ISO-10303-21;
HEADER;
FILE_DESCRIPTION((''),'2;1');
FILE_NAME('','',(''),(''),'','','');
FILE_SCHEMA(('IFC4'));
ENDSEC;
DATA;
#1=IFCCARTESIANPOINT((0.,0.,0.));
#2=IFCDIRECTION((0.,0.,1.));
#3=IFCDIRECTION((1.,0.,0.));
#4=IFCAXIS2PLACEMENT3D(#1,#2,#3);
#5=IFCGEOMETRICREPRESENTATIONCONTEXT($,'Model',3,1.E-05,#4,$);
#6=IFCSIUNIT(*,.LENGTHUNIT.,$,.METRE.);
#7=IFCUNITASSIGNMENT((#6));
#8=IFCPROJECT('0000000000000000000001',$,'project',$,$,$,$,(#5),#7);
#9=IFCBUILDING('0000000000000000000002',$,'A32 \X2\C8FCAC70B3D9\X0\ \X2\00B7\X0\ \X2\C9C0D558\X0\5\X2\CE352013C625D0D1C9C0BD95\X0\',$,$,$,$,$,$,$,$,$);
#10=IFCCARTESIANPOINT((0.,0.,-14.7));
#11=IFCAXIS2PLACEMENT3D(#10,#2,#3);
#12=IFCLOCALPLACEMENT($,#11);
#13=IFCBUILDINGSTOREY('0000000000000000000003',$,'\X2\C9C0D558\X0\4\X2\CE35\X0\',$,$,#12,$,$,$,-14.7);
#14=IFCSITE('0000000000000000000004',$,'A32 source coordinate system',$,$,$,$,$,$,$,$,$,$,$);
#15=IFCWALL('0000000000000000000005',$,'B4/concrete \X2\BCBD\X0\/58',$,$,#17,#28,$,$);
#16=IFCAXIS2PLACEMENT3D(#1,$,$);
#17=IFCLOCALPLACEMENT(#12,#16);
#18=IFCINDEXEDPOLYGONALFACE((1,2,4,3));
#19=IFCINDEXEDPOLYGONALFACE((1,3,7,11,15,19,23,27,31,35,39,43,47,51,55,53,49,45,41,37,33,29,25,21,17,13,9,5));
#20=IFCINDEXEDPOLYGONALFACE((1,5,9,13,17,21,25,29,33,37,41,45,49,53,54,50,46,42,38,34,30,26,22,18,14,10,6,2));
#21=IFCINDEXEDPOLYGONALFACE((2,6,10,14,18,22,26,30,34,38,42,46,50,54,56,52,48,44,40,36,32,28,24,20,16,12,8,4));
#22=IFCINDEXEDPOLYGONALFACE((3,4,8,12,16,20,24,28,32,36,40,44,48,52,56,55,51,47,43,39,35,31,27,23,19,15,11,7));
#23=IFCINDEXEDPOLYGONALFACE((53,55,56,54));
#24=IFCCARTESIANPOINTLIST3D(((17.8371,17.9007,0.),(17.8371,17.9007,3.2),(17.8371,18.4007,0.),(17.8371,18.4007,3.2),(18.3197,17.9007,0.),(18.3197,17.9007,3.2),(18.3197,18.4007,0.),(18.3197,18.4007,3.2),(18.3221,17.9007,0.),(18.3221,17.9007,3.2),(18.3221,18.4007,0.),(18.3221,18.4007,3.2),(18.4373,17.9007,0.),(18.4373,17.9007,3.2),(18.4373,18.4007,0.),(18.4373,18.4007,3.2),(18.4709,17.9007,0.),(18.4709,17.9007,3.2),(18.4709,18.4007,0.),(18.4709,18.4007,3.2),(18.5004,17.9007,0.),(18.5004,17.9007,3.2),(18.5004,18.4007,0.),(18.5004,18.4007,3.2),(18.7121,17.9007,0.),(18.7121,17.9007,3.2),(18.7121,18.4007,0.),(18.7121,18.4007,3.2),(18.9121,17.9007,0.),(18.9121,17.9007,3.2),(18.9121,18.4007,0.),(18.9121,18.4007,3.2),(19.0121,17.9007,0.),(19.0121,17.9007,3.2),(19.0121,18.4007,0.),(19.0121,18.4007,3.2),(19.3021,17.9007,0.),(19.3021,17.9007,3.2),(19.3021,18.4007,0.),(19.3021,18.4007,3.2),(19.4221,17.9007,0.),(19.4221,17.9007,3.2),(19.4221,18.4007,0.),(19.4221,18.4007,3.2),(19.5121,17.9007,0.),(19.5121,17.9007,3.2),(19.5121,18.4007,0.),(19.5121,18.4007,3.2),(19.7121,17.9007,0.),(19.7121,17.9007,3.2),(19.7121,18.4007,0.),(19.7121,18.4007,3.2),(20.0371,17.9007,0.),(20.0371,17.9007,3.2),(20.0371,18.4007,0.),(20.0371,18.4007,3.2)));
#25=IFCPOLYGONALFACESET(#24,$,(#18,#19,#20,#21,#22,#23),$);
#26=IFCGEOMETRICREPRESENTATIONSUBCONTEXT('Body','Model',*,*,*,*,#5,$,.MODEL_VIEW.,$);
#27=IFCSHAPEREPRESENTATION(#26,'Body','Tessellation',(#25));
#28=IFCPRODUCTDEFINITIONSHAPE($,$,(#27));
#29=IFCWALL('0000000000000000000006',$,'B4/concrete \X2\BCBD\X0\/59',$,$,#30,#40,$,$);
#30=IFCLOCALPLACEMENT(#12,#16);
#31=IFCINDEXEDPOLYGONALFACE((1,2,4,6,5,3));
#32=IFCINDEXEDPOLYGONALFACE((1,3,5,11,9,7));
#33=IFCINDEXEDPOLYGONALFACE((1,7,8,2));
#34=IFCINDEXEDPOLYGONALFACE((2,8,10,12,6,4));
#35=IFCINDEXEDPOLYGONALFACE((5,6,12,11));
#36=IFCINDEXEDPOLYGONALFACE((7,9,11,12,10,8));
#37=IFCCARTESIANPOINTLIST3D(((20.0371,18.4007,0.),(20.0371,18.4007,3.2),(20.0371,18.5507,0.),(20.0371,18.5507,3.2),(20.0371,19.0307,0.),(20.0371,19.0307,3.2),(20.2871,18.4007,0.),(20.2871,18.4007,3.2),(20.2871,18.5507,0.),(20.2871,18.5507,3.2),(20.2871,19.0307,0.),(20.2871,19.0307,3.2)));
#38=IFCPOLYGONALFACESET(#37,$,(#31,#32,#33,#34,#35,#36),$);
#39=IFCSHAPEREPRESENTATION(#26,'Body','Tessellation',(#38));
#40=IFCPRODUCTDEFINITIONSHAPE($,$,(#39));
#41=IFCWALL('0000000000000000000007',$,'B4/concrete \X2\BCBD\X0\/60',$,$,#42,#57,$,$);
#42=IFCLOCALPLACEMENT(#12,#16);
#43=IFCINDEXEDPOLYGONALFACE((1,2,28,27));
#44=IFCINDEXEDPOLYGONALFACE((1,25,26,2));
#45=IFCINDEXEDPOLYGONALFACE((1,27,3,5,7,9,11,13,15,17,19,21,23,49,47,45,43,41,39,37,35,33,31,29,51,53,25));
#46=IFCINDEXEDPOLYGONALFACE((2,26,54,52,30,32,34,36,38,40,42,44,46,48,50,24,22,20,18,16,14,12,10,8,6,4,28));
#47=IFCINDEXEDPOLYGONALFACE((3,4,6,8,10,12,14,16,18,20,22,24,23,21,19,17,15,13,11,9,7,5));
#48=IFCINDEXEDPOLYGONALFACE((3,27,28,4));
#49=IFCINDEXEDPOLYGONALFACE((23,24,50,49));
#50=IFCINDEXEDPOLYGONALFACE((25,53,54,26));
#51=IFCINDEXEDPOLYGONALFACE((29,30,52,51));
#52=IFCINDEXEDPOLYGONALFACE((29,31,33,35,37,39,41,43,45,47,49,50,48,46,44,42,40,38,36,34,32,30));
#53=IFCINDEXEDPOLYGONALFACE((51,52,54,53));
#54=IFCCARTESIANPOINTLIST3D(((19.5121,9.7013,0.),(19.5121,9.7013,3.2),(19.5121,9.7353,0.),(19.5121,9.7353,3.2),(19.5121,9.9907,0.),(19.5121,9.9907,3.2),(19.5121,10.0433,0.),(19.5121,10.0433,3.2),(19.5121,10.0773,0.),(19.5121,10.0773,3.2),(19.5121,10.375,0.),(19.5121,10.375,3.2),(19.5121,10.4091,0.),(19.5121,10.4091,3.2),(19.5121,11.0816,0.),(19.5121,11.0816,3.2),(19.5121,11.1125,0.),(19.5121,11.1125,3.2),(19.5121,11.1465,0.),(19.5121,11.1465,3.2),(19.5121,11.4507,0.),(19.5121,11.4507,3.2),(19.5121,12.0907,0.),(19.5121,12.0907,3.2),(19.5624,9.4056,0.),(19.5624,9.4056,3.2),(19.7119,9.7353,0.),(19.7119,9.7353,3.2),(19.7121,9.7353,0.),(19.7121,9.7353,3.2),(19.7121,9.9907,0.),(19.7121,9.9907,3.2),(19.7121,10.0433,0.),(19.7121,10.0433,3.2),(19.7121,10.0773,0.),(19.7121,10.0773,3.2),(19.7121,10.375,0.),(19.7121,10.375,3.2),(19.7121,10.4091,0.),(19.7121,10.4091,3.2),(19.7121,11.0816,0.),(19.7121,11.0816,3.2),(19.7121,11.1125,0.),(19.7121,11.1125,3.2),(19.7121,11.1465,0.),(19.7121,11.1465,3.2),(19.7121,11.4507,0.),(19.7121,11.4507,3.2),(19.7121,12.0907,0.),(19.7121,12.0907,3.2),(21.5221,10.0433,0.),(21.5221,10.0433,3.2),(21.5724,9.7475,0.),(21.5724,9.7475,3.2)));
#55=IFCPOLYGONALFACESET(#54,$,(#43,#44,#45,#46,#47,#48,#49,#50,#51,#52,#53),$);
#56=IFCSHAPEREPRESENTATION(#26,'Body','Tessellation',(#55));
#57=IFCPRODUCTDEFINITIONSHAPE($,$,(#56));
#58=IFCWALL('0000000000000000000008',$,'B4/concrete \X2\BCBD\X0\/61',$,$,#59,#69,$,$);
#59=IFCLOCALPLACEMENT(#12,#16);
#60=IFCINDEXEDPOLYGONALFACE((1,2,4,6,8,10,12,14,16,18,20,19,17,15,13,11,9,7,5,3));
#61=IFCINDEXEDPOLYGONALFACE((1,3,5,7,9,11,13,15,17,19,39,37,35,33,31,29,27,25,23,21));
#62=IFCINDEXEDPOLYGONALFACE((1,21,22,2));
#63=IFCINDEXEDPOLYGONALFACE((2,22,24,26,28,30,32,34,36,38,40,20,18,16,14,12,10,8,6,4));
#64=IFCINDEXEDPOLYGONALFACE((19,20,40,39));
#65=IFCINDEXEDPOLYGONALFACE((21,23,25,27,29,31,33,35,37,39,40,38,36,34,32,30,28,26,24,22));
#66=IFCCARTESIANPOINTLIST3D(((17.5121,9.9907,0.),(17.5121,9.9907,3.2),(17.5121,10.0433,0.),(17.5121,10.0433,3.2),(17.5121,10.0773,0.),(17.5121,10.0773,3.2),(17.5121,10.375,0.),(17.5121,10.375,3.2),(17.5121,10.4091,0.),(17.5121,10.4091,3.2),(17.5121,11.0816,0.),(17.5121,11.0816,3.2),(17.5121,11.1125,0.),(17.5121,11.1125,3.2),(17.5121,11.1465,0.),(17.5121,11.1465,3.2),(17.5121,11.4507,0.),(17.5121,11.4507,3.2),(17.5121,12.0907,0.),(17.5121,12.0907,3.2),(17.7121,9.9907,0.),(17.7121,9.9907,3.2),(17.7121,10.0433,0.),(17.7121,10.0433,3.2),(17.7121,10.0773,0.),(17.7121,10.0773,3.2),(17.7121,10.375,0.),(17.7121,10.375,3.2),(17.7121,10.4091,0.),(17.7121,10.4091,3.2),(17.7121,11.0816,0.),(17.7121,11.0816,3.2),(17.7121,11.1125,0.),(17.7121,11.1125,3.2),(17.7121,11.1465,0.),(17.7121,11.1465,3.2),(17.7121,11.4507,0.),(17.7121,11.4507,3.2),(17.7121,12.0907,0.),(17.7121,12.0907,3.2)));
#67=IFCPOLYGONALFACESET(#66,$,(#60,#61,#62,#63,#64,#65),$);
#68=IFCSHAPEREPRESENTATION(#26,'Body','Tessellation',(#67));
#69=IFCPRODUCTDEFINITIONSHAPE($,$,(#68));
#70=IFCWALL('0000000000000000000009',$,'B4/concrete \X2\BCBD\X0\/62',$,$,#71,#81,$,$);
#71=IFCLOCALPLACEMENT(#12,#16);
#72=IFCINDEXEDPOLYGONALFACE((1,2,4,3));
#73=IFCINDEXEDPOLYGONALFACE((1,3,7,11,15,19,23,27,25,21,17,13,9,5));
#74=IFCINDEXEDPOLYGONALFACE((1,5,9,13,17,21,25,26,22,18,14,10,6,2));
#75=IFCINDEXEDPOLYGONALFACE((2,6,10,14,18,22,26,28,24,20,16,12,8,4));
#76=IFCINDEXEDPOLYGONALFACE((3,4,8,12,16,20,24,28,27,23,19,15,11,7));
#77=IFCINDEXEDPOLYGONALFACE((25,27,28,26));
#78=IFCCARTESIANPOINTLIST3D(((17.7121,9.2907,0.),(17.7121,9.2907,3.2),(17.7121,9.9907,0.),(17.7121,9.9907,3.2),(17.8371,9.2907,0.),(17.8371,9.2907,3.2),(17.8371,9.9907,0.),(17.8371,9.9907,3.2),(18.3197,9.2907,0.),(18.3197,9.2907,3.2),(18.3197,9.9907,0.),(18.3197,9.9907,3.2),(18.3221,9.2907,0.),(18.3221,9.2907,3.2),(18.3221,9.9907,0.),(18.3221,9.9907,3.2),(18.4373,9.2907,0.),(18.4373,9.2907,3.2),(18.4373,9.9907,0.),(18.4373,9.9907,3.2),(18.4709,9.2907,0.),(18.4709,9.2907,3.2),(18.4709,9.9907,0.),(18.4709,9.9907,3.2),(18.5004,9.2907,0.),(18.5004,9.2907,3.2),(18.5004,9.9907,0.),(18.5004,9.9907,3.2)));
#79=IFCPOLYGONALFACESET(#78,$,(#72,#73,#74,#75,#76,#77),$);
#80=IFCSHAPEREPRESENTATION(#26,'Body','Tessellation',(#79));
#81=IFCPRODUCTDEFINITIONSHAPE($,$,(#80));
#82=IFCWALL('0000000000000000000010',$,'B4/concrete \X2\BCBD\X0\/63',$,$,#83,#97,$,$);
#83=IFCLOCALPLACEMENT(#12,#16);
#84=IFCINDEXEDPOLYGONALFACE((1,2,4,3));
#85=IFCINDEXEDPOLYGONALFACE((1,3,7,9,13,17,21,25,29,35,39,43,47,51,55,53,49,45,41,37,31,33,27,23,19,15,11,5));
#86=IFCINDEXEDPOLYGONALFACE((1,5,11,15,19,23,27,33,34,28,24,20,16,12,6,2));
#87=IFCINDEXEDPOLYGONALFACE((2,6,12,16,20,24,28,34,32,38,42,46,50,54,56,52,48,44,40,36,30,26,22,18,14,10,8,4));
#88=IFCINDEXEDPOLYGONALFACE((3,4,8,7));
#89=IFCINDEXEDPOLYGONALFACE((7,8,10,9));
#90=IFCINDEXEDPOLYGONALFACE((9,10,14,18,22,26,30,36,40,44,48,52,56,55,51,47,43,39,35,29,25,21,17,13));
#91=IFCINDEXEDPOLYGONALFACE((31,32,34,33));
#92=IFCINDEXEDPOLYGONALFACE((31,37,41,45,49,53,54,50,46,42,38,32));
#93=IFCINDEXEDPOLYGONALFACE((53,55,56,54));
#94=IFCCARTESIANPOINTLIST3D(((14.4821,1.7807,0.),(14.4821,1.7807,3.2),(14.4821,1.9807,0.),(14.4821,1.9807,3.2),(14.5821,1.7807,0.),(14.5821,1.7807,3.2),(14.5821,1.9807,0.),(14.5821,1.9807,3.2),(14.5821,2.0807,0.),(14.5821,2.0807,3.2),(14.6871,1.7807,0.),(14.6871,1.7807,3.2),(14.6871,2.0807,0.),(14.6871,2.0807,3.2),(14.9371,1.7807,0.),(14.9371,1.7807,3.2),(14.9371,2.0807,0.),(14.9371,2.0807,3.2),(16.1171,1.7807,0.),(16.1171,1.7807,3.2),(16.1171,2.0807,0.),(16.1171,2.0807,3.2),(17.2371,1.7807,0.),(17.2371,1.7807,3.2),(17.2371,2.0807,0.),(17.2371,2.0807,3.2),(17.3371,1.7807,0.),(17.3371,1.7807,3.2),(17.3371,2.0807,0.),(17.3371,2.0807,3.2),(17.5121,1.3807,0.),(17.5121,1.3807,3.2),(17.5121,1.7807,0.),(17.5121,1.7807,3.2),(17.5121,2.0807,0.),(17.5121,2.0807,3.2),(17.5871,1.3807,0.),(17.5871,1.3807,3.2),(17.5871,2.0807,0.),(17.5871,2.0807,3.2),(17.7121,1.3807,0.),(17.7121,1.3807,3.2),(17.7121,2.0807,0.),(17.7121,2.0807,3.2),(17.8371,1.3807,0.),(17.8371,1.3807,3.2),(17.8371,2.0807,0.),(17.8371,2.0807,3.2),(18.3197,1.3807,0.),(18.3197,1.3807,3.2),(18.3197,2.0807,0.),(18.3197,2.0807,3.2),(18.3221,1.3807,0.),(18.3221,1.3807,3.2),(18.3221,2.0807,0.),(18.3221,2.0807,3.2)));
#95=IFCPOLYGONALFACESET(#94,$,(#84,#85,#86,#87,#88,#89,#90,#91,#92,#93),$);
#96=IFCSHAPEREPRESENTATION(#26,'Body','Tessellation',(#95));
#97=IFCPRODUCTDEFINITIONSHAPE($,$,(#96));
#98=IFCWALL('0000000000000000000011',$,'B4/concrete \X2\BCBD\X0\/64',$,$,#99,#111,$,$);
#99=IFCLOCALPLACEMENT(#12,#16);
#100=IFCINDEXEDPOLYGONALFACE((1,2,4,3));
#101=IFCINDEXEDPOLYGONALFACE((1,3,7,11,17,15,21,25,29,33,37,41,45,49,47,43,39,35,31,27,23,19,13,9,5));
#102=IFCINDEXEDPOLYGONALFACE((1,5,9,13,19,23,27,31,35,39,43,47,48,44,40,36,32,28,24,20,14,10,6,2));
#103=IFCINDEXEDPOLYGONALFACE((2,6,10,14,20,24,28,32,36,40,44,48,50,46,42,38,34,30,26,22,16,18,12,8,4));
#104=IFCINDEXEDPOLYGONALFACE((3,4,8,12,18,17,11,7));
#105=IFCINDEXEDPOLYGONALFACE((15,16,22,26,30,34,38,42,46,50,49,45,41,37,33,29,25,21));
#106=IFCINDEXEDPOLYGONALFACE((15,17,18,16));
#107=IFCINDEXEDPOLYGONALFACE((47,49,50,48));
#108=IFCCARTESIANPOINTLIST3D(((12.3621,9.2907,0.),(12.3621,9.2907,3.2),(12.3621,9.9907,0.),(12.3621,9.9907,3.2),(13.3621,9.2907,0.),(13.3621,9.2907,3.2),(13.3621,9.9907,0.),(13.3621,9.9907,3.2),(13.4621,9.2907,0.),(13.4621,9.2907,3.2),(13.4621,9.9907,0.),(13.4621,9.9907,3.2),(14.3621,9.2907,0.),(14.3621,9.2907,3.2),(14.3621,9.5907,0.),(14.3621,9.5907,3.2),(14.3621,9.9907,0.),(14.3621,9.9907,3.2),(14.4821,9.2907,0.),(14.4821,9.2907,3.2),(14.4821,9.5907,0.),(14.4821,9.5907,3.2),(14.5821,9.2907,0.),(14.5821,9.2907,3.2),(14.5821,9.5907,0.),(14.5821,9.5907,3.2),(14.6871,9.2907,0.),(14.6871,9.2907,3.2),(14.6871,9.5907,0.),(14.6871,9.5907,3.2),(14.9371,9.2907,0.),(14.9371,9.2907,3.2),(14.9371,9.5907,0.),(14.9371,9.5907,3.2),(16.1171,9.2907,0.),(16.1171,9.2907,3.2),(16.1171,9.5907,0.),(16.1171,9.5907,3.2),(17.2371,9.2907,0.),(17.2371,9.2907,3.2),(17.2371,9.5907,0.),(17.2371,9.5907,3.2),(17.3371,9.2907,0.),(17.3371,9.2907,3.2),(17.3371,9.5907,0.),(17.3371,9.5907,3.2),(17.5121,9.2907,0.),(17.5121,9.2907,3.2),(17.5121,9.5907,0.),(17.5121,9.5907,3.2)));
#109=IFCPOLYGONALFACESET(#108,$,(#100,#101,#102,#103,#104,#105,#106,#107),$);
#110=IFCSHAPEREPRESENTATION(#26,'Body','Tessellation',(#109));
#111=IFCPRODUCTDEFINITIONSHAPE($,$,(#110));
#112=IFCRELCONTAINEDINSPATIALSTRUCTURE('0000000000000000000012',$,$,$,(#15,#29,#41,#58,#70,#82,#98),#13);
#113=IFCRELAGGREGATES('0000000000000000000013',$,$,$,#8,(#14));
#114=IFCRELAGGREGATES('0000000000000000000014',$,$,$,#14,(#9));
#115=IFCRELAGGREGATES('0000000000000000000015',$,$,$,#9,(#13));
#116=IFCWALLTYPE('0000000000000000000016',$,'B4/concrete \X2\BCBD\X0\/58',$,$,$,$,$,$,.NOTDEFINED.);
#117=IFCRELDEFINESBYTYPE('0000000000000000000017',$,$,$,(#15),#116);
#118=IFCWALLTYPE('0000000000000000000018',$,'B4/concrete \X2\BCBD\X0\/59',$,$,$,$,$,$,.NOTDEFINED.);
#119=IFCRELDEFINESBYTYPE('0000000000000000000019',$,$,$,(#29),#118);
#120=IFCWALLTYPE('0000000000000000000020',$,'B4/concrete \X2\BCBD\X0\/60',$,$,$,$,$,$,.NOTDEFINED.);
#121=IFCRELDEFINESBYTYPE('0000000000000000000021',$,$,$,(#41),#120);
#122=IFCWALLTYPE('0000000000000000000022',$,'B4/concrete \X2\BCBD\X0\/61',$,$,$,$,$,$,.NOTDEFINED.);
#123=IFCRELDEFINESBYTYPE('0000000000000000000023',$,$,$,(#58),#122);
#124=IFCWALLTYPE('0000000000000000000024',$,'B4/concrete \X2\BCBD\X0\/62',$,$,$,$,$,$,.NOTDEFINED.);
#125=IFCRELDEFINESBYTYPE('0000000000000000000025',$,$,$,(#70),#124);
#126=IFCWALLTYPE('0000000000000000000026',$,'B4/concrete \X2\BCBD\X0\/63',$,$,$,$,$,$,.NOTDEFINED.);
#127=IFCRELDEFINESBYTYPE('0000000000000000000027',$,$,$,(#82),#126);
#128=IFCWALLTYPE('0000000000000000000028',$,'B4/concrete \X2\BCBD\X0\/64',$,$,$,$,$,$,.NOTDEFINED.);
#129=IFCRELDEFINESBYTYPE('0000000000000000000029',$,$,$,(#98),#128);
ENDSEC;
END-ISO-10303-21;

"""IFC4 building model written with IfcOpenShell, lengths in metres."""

from ifc_helpers import new_model, si_unit, frame, origin, origin_with_axes, place, context, subcontext, project, spatial, polyline, outline, extrude, source, transform, mapped, type_object, type_shapes, element, save


model = new_model("IFC4")

# Units and contexts
model_context = context("Model", 3, precision=1e-05, world=origin_with_axes())
body_context = subcontext(model_context, "Body", "Model", "MODEL_VIEW")
ifc_project = project(units=[si_unit("LENGTHUNIT", "METRE")], contexts=[model_context])

# Site, building, storey
site = spatial("IfcSite", under=ifc_project, Name="A32 source coordinate system")
building = spatial("IfcBuilding", under=site, Name="A32 주거동 · 지하5층–옥탑지붕")
storey_placement = place(None, frame((0.0, 0.0, -14.7), z_axis=(0.0, 0.0, 1.0), x_axis=(1.0, 0.0, 0.0)))
storey = spatial("IfcBuildingStorey", under=building, at=storey_placement, Name="지하4층", Elevation=-14.7)

# Walls
wall_type_1 = type_object("IfcWallType", Name="B4/concrete 벽/58", PredefinedType="NOTDEFINED")
shared_shape_1 = source(origin(), body_context, "Body", "SweptSolid", [
    extrude(outline(polyline([(18.3221, 18.4007), (18.4373, 18.4007), (18.4709, 18.4007), (18.5004, 18.4007), (18.7121, 18.4007), (18.9121, 18.4007), (19.0121, 18.4007), (19.3021, 18.4007), (19.4221, 18.4007), (19.5121, 18.4007), (19.7121, 18.4007), (20.0371, 18.4007), (20.0371, 17.9007), (19.7121, 17.9007), (19.5121, 17.9007), (19.4221, 17.9007), (19.3021, 17.9007), (19.0121, 17.9007), (18.9121, 17.9007), (18.7121, 17.9007), (18.5004, 17.9007), (18.4709, 17.9007), (18.4373, 17.9007), (18.3221, 17.9007), (18.3197, 17.9007), (17.8371, 17.9007), (17.8371, 18.4007), (18.3197, 18.4007), (18.3221, 18.4007)])), origin(), (0.0, 0.0, 1.0), 3.2),
])
type_shapes(wall_type_1, [shared_shape_1])
wall_1_placement = place(storey_placement, origin_with_axes())
element("IfcWall", 1, at=wall_1_placement, inside=storey, type_object=wall_type_1, Name="B4/concrete 벽/58", context=body_context, shape_type="MappedRepresentation", body=[
    mapped(shared_shape_1, transform((0.0, 0.0, 0.0), scale=1.0)),
])
wall_type_2 = type_object("IfcWallType", Name="B4/concrete 벽/59", PredefinedType="NOTDEFINED")
shared_shape_2 = source(origin(), body_context, "Body", "SweptSolid", [
    extrude(outline(polyline([(20.2871, 19.0307), (20.2871, 18.5507), (20.2871, 18.4007), (20.0371, 18.4007), (20.0371, 18.5507), (20.0371, 19.0307), (20.2871, 19.0307)])), origin(), (0.0, 0.0, 1.0), 3.2),
])
type_shapes(wall_type_2, [shared_shape_2])
wall_2_placement = place(storey_placement, origin_with_axes())
element("IfcWall", 2, at=wall_2_placement, inside=storey, type_object=wall_type_2, Name="B4/concrete 벽/59", context=body_context, shape_type="MappedRepresentation", body=[
    mapped(shared_shape_2, transform((0.0, 0.0, 0.0), scale=1.0)),
])
wall_type_3 = type_object("IfcWallType", Name="B4/concrete 벽/60", PredefinedType="NOTDEFINED")
shared_shape_3 = source(origin(), body_context, "Body", "SweptSolid", [
    extrude(outline(polyline([(19.5121, 11.1465), (19.5121, 11.4507), (19.5121, 12.0907), (19.7121, 12.0907), (19.7121, 11.4507), (19.7121, 11.1465), (19.7121, 11.1125), (19.7121, 11.0816), (19.7121, 10.4091), (19.7121, 10.375), (19.7121, 10.0773), (19.7121, 10.0433), (19.7121, 9.9907), (19.7121, 9.7353), (21.5221, 10.0433), (21.5724, 9.7475), (19.5624, 9.4056), (19.5121, 9.7013), (19.7119, 9.7353), (19.5121, 9.7353), (19.5121, 9.9907), (19.5121, 10.0433), (19.5121, 10.0773), (19.5121, 10.375), (19.5121, 10.4091), (19.5121, 11.0816), (19.5121, 11.1125), (19.5121, 11.1465)])), origin(), (0.0, 0.0, 1.0), 3.2),
])
type_shapes(wall_type_3, [shared_shape_3])
wall_3_placement = place(storey_placement, origin_with_axes())
element("IfcWall", 3, at=wall_3_placement, inside=storey, type_object=wall_type_3, Name="B4/concrete 벽/60", context=body_context, shape_type="MappedRepresentation", body=[
    mapped(shared_shape_3, transform((0.0, 0.0, 0.0), scale=1.0)),
])
wall_type_4 = type_object("IfcWallType", Name="B4/concrete 벽/61", PredefinedType="NOTDEFINED")
shared_shape_4 = source(origin(), body_context, "Body", "SweptSolid", [
    extrude(outline(polyline([(17.5121, 11.4507), (17.5121, 12.0907), (17.7121, 12.0907), (17.7121, 11.4507), (17.7121, 11.1465), (17.7121, 11.1125), (17.7121, 11.0816), (17.7121, 10.4091), (17.7121, 10.375), (17.7121, 10.0773), (17.7121, 10.0433), (17.7121, 9.9907), (17.5121, 9.9907), (17.5121, 10.0433), (17.5121, 10.0773), (17.5121, 10.375), (17.5121, 10.4091), (17.5121, 11.0816), (17.5121, 11.1125), (17.5121, 11.1465), (17.5121, 11.4507)])), origin(), (0.0, 0.0, 1.0), 3.2),
])
type_shapes(wall_type_4, [shared_shape_4])
wall_4_placement = place(storey_placement, origin_with_axes())
element("IfcWall", 4, at=wall_4_placement, inside=storey, type_object=wall_type_4, Name="B4/concrete 벽/61", context=body_context, shape_type="MappedRepresentation", body=[
    mapped(shared_shape_4, transform((0.0, 0.0, 0.0), scale=1.0)),
])
wall_type_5 = type_object("IfcWallType", Name="B4/concrete 벽/62", PredefinedType="NOTDEFINED")
shared_shape_5 = source(origin(), body_context, "Body", "SweptSolid", [
    extrude(outline(polyline([(18.3221, 9.9907), (18.4373, 9.9907), (18.4709, 9.9907), (18.5004, 9.9907), (18.5004, 9.2907), (18.4709, 9.2907), (18.4373, 9.2907), (18.3221, 9.2907), (18.3197, 9.2907), (17.8371, 9.2907), (17.7121, 9.2907), (17.7121, 9.9907), (17.8371, 9.9907), (18.3197, 9.9907), (18.3221, 9.9907)])), origin(), (0.0, 0.0, 1.0), 3.2),
])
type_shapes(wall_type_5, [shared_shape_5])
wall_5_placement = place(storey_placement, origin_with_axes())
element("IfcWall", 5, at=wall_5_placement, inside=storey, type_object=wall_type_5, Name="B4/concrete 벽/62", context=body_context, shape_type="MappedRepresentation", body=[
    mapped(shared_shape_5, transform((0.0, 0.0, 0.0), scale=1.0)),
])
wall_type_6 = type_object("IfcWallType", Name="B4/concrete 벽/63", PredefinedType="NOTDEFINED")
shared_shape_6 = source(origin(), body_context, "Body", "SweptSolid", [
    extrude(outline(polyline([(14.6871, 2.0807), (14.9371, 2.0807), (16.1171, 2.0807), (17.2371, 2.0807), (17.3371, 2.0807), (17.5121, 2.0807), (17.5871, 2.0807), (17.7121, 2.0807), (17.8371, 2.0807), (18.3197, 2.0807), (18.3221, 2.0807), (18.3221, 1.3807), (18.3197, 1.3807), (17.8371, 1.3807), (17.7121, 1.3807), (17.5871, 1.3807), (17.5121, 1.3807), (17.5121, 1.7807), (17.3371, 1.7807), (17.2371, 1.7807), (16.1171, 1.7807), (14.9371, 1.7807), (14.6871, 1.7807), (14.5821, 1.7807), (14.4821, 1.7807), (14.4821, 1.9807), (14.5821, 1.9807), (14.5821, 2.0807), (14.6871, 2.0807)])), origin(), (0.0, 0.0, 1.0), 3.2),
])
type_shapes(wall_type_6, [shared_shape_6])
wall_6_placement = place(storey_placement, origin_with_axes())
element("IfcWall", 6, at=wall_6_placement, inside=storey, type_object=wall_type_6, Name="B4/concrete 벽/63", context=body_context, shape_type="MappedRepresentation", body=[
    mapped(shared_shape_6, transform((0.0, 0.0, 0.0), scale=1.0)),
])
wall_type_7 = type_object("IfcWallType", Name="B4/concrete 벽/64", PredefinedType="NOTDEFINED")
shared_shape_7 = source(origin(), body_context, "Body", "SweptSolid", [
    extrude(outline(polyline([(14.4821, 9.5907), (14.5821, 9.5907), (14.6871, 9.5907), (14.9371, 9.5907), (16.1171, 9.5907), (17.2371, 9.5907), (17.3371, 9.5907), (17.5121, 9.5907), (17.5121, 9.2907), (17.3371, 9.2907), (17.2371, 9.2907), (16.1171, 9.2907), (14.9371, 9.2907), (14.6871, 9.2907), (14.5821, 9.2907), (14.4821, 9.2907), (14.3621, 9.2907), (13.4621, 9.2907), (13.3621, 9.2907), (12.3621, 9.2907), (12.3621, 9.9907), (13.3621, 9.9907), (13.4621, 9.9907), (14.3621, 9.9907), (14.3621, 9.5907), (14.4821, 9.5907)])), origin(), (0.0, 0.0, 1.0), 3.2),
])
type_shapes(wall_type_7, [shared_shape_7])
wall_7_placement = place(storey_placement, origin_with_axes())
element("IfcWall", 7, at=wall_7_placement, inside=storey, type_object=wall_type_7, Name="B4/concrete 벽/64", context=body_context, shape_type="MappedRepresentation", body=[
    mapped(shared_shape_7, transform((0.0, 0.0, 0.0), scale=1.0)),
])

save(model, "model.ifc")
